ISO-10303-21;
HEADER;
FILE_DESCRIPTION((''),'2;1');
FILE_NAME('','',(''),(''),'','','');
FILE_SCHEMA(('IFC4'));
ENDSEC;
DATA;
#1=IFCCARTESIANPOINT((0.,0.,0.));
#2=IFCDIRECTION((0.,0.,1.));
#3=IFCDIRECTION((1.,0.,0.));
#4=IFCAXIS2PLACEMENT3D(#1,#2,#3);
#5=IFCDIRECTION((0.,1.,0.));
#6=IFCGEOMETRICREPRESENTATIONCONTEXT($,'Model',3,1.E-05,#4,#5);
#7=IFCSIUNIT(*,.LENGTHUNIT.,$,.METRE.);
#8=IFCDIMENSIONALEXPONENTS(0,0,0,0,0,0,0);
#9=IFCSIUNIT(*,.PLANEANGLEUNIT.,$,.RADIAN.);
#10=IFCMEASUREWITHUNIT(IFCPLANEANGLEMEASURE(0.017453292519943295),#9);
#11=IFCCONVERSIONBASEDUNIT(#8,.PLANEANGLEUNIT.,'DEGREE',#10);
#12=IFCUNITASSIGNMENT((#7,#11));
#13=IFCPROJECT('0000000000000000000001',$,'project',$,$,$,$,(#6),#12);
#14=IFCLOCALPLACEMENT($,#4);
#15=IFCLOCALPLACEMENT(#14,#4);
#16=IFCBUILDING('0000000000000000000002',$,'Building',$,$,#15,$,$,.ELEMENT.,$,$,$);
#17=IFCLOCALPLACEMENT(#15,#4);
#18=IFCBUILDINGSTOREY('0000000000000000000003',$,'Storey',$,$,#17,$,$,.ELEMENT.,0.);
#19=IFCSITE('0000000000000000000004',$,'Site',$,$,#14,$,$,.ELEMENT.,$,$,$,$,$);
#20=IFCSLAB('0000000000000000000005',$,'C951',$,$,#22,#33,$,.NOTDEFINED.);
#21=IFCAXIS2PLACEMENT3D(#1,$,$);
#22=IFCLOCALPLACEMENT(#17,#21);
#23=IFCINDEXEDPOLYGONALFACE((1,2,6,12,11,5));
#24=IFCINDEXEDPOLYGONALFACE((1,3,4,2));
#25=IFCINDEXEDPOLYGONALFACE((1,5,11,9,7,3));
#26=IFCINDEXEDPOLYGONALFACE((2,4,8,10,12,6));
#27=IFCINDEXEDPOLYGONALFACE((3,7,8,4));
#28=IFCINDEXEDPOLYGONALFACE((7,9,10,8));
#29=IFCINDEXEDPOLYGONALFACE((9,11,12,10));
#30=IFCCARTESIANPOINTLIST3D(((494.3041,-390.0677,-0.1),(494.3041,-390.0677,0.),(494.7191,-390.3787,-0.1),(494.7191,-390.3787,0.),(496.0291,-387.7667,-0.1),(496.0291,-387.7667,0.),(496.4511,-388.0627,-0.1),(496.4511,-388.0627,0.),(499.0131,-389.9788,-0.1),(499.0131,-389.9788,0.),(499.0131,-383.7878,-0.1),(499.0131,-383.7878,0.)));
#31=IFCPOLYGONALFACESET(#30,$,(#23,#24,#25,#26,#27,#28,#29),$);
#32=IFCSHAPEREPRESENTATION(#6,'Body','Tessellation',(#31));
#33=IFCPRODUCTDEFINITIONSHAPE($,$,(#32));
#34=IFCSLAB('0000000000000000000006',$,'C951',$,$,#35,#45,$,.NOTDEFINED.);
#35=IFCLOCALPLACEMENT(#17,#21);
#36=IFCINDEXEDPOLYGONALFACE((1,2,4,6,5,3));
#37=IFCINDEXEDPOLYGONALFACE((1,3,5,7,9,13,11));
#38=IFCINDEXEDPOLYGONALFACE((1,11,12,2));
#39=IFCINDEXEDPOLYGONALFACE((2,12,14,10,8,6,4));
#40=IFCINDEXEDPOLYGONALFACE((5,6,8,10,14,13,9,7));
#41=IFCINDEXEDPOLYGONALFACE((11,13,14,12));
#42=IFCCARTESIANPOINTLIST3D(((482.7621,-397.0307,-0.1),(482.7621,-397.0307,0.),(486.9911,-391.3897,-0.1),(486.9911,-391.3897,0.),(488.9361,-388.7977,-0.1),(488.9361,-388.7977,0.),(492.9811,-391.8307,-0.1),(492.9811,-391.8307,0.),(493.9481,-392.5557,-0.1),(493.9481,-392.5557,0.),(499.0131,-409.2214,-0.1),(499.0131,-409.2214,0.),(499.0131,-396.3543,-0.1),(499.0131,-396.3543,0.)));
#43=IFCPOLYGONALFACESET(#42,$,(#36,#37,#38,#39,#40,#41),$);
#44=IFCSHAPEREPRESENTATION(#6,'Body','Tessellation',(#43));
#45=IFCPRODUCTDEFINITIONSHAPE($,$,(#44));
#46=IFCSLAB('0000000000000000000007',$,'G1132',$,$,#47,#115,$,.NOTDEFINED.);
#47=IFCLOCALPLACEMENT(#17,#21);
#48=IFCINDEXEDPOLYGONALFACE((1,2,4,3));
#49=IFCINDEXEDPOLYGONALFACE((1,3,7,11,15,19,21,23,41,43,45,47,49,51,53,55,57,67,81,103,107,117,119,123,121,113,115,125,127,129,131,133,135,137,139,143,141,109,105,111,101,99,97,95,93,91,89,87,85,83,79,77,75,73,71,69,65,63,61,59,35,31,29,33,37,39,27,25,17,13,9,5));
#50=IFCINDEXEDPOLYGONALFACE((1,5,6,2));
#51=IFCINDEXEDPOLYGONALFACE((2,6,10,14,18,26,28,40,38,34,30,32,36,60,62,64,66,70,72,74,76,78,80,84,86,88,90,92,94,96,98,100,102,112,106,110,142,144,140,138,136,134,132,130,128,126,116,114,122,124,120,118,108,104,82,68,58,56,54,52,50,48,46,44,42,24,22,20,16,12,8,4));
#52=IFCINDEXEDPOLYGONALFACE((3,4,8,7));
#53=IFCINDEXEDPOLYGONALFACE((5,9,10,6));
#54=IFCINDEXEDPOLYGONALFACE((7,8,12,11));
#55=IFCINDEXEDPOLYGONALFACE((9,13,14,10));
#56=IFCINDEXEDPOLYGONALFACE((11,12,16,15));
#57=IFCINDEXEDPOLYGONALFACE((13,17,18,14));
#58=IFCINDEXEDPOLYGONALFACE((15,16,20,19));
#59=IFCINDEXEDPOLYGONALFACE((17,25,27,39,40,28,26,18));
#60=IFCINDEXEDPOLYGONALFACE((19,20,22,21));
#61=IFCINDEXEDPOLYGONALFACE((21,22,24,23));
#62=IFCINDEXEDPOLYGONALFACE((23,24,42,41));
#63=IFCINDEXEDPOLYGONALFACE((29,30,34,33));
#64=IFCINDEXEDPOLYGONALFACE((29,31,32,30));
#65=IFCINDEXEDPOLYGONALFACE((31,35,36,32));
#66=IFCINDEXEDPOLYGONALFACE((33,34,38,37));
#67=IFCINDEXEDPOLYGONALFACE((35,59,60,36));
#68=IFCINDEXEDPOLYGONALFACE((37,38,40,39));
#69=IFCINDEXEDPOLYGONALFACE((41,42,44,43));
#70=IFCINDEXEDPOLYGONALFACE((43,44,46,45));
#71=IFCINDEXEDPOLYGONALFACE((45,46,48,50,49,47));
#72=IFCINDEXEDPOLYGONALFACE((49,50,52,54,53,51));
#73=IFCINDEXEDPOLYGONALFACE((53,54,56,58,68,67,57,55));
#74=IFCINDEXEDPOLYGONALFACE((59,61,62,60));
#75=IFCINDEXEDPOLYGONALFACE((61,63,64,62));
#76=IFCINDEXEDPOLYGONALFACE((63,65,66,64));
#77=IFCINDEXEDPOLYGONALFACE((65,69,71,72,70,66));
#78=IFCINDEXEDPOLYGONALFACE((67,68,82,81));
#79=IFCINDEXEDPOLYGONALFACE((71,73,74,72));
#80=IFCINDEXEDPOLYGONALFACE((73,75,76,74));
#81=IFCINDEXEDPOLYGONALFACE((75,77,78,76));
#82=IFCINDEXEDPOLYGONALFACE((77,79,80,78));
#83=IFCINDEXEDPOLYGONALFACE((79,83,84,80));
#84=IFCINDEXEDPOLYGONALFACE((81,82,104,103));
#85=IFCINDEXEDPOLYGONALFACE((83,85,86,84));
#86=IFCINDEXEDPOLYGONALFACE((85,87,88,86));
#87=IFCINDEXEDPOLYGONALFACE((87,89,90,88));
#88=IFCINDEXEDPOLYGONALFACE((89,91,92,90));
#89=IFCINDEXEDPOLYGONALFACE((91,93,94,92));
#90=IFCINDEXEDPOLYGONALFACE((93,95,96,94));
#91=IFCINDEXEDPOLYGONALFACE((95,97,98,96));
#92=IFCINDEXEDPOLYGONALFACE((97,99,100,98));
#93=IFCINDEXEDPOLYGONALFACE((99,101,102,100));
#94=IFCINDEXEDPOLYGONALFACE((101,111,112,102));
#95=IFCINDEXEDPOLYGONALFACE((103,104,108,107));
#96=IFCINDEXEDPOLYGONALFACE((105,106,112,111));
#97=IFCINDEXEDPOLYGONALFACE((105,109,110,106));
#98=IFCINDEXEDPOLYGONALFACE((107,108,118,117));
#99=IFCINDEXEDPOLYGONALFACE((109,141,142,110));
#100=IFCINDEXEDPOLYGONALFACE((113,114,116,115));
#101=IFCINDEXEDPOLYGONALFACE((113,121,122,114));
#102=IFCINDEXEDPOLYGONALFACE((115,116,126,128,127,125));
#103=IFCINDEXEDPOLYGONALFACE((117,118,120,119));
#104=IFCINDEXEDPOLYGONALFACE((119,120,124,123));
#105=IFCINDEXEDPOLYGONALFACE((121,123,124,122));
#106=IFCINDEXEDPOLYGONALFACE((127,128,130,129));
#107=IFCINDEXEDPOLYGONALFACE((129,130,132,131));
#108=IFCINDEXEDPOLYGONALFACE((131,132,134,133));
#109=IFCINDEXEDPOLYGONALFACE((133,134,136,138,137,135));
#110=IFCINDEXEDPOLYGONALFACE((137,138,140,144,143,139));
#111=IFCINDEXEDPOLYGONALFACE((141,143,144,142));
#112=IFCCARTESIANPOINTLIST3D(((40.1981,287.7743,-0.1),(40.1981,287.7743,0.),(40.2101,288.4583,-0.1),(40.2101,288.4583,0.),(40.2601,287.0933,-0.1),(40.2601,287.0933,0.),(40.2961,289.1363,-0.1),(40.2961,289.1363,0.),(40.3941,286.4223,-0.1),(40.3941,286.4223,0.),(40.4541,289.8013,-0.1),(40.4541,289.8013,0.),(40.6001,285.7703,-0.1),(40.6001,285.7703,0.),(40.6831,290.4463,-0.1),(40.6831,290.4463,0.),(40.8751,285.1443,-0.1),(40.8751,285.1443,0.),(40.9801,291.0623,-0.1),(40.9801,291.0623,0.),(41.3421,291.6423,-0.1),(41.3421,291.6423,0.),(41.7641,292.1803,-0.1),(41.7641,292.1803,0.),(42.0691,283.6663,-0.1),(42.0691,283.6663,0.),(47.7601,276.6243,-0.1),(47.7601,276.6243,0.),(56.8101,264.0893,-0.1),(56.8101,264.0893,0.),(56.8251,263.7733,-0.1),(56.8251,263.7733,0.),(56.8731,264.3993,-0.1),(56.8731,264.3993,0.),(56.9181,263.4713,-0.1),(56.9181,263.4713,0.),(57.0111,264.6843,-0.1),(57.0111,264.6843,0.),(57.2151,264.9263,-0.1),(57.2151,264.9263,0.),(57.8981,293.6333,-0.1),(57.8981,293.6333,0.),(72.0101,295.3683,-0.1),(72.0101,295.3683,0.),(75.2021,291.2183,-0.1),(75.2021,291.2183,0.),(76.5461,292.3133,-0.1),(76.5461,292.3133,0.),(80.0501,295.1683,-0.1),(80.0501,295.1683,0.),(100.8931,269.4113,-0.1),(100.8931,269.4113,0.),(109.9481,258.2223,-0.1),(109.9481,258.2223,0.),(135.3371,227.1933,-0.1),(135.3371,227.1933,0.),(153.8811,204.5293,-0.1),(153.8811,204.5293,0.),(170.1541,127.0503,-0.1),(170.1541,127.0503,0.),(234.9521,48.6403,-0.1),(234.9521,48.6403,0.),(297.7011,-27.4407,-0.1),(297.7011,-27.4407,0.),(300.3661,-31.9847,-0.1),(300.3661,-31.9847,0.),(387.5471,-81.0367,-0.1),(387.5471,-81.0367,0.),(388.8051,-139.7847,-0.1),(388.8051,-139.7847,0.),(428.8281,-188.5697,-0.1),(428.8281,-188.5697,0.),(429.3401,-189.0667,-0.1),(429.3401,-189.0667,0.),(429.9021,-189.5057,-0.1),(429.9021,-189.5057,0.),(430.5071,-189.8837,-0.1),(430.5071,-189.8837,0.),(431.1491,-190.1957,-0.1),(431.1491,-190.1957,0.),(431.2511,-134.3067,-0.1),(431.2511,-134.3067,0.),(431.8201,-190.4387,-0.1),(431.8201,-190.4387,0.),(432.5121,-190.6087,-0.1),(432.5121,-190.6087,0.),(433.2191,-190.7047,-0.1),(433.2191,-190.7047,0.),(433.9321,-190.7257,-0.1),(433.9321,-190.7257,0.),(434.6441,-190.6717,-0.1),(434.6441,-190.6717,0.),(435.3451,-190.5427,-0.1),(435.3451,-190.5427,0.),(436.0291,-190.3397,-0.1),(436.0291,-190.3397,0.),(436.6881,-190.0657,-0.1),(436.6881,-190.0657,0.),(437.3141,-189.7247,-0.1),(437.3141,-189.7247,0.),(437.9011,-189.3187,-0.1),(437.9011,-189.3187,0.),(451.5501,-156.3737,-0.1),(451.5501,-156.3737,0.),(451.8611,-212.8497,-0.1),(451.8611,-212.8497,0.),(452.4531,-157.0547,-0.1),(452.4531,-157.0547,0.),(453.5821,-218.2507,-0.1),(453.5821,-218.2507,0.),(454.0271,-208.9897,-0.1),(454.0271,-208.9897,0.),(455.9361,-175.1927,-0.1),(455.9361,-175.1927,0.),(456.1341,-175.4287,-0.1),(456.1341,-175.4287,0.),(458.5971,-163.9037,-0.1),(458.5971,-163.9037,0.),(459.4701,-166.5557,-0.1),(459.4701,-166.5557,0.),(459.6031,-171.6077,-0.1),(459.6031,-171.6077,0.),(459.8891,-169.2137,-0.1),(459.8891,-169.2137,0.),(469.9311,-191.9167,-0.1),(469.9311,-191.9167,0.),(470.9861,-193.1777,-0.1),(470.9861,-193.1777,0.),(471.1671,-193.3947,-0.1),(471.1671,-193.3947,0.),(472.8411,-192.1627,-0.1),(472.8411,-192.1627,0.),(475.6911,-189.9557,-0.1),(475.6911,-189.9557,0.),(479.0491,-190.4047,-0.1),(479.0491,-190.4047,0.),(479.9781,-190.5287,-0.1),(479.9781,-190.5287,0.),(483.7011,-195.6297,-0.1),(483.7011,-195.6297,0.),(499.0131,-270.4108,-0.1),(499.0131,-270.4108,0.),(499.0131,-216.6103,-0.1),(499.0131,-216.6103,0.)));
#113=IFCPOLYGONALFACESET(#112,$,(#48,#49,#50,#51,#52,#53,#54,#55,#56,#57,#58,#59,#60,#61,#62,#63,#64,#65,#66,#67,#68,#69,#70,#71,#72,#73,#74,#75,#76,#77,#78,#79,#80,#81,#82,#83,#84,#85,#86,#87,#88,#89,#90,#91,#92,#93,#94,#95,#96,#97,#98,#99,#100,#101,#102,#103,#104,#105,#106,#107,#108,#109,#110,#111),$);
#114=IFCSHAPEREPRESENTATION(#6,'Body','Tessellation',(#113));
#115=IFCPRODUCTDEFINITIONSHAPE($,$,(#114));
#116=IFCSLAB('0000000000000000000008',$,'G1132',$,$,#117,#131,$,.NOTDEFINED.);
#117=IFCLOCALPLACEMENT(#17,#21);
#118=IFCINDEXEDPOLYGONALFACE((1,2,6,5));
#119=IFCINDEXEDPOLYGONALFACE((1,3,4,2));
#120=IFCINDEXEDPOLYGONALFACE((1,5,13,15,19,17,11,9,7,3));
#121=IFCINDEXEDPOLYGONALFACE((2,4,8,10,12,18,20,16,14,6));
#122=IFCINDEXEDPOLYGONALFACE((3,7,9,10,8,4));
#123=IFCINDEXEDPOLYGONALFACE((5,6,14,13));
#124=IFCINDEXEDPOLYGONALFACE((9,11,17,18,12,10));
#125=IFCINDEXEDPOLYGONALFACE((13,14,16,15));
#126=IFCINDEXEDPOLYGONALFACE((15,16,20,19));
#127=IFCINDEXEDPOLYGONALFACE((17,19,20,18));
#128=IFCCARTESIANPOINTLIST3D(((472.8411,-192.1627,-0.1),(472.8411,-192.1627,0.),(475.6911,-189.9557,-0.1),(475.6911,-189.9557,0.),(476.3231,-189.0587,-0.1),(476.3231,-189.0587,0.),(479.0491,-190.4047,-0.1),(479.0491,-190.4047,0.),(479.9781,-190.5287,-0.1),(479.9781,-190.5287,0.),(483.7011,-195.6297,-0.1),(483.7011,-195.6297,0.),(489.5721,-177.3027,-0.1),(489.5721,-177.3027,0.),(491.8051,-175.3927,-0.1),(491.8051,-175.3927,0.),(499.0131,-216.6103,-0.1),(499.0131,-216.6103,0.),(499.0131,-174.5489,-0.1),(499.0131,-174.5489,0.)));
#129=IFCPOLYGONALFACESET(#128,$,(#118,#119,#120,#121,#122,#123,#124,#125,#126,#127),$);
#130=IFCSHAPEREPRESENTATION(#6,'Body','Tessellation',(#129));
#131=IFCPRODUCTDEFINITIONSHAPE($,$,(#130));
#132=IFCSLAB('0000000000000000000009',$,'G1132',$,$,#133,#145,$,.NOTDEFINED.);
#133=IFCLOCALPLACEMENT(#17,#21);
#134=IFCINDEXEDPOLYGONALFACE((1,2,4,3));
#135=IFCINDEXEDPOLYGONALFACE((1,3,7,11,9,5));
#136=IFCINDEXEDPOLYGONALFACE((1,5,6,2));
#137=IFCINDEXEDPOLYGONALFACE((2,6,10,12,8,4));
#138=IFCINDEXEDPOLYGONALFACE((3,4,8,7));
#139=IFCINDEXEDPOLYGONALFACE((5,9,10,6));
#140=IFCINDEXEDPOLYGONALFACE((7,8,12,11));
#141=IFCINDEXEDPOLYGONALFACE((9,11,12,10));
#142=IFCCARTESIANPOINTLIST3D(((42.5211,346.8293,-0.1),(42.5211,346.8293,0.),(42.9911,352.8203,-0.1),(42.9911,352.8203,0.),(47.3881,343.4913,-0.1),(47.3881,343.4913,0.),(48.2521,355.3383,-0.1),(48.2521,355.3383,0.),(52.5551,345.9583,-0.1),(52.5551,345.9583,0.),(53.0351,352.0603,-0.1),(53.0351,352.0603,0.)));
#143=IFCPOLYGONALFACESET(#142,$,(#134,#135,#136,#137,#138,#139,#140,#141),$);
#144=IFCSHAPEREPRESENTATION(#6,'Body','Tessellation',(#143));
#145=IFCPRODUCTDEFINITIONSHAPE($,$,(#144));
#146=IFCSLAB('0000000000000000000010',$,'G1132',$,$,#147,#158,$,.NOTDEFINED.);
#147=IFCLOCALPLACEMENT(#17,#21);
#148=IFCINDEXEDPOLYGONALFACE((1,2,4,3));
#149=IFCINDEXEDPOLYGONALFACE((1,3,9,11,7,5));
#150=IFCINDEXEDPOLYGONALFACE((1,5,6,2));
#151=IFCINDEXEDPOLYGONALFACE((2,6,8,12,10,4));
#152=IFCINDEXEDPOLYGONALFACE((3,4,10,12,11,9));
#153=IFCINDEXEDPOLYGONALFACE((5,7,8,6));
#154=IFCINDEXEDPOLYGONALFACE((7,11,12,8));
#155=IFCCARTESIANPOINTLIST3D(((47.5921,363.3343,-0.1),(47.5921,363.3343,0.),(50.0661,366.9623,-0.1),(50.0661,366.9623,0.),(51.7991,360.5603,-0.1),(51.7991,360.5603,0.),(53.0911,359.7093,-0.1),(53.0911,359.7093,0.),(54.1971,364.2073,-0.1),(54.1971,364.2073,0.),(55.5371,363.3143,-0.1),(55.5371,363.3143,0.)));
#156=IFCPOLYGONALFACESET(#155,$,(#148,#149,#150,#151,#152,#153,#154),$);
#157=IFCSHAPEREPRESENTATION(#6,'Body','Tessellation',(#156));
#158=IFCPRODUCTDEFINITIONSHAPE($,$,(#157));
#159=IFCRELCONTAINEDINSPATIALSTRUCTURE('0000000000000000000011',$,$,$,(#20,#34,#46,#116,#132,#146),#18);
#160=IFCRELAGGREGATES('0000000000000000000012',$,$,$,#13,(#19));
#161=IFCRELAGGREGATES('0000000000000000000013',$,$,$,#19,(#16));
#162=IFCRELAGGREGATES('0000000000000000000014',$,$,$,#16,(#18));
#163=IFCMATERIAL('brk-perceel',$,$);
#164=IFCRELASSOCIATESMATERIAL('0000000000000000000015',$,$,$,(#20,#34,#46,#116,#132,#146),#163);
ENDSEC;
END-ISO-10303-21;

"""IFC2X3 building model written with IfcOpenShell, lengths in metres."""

from ifc_helpers import new_model, entity, si_unit, converted_unit, direction, frame, origin_with_axes, place, context, project, spatial, polyline, outline, extrude, material, element, save


model = new_model("IFC2X3")

# Units and contexts
model_context = context("Model", 3, precision=1e-05, world=origin_with_axes(), true_north=direction((0.0, 1.0, 0.0)))
ifc_project = project(units=[si_unit("LENGTHUNIT", "METRE"), converted_unit("PLANEANGLEUNIT", "DEGREE", entity("IfcPlaneAngleMeasure", 0.017453292519943295), si_unit("PLANEANGLEUNIT", "RADIAN"), dimensions=[0, 0, 0, 0, 0, 0, 0])], contexts=[model_context])

# Site, building, storey
site_placement = place(None, origin_with_axes())
site = spatial("IfcSite", under=ifc_project, at=site_placement, Name="Site", CompositionType="ELEMENT")
building_placement = place(site_placement, origin_with_axes())
building = spatial("IfcBuilding", under=site, at=building_placement, Name="Building", CompositionType="ELEMENT")
storey_placement = place(building_placement, origin_with_axes())
storey = spatial("IfcBuildingStorey", under=building, at=storey_placement, Name="Storey", CompositionType="ELEMENT", Elevation=0.0)

# Slabs
ifc_material = material(Name="brk-perceel")
slab_1_placement = place(storey_placement, frame((0.0, 0.0, -0.1), z_axis=(0.0, 0.0, 1.0), x_axis=(1.0, 0.0, 0.0)))
element("IfcSlab", 1, at=slab_1_placement, inside=storey, material=ifc_material, Name="C951", PredefinedType="NOTDEFINED", context=model_context, shape_type="SweptSolid", body=[
    extrude(outline(polyline([(496.4511, -388.0627), (494.7191, -390.3787), (494.3041, -390.0677), (496.0291, -387.7667), (499.0131, -383.7878), (499.0131, -389.9788), (496.4511, -388.0627)])), origin_with_axes(), (0.0, 0.0, 1.0), 0.1),
])
slab_2_placement = place(storey_placement, frame((0.0, 0.0, -0.1), z_axis=(0.0, 0.0, 1.0), x_axis=(1.0, 0.0, 0.0)))
element("IfcSlab", 2, at=slab_2_placement, inside=storey, material=ifc_material, Name="C951", PredefinedType="NOTDEFINED", context=model_context, shape_type="SweptSolid", body=[
    extrude(outline(polyline([(482.7621, -397.0307), (486.9911, -391.3897), (488.9361, -388.7977), (492.9811, -391.8307), (493.9481, -392.5557), (499.0131, -396.3543), (499.0131, -409.2214), (482.7621, -397.0307)])), origin_with_axes(), (0.0, 0.0, 1.0), 0.1),
])
slab_3_placement = place(storey_placement, frame((0.0, 0.0, -0.1), z_axis=(0.0, 0.0, 1.0), x_axis=(1.0, 0.0, 0.0)))
element("IfcSlab", 3, at=slab_3_placement, inside=storey, material=ifc_material, Name="G1132", PredefinedType="NOTDEFINED", context=model_context, shape_type="SweptSolid", body=[
    extrude(outline(polyline([(453.5821, -218.2507), (451.8611, -212.8497), (454.0271, -208.9897), (437.9011, -189.3187), (437.3141, -189.7247), (436.6881, -190.0657), (436.0291, -190.3397), (435.3451, -190.5427), (434.6441, -190.6717), (433.9321, -190.7257), (433.2191, -190.7047), (432.5121, -190.6087), (431.8201, -190.4387), (431.1491, -190.1957), (430.5071, -189.8837), (429.9021, -189.5057), (429.3401, -189.0667), (428.8281, -188.5697), (388.8051, -139.7847), (300.3661, -31.9847), (297.7011, -27.4407), (234.9521, 48.6403), (170.1541, 127.0503), (56.9181, 263.4713), (56.8251, 263.7733), (56.8101, 264.0893), (56.8731, 264.3993), (57.0111, 264.6843), (57.2151, 264.9263), (47.7601, 276.6243), (42.0691, 283.6663), (40.8751, 285.1443), (40.6001, 285.7703), (40.3941, 286.4223), (40.2601, 287.0933), (40.1981, 287.7743), (40.2101, 288.4583), (40.2961, 289.1363), (40.4541, 289.8013), (40.6831, 290.4463), (40.9801, 291.0623), (41.3421, 291.6423), (41.7641, 292.1803), (57.8981, 293.6333), (72.0101, 295.3683), (75.2021, 291.2183), (76.5461, 292.3133), (80.0501, 295.1683), (100.8931, 269.4113), (109.9481, 258.2223), (135.3371, 227.1933), (153.8811, 204.5293), (387.5471, -81.0367), (431.2511, -134.3067), (451.5501, -156.3737), (452.4531, -157.0547), (458.5971, -163.9037), (459.4701, -166.5557), (459.8891, -169.2137), (459.6031, -171.6077), (455.9361, -175.1927), (456.1341, -175.4287), (469.9311, -191.9167), (470.9861, -193.1777), (471.1671, -193.3947), (472.8411, -192.1627), (475.6911, -189.9557), (479.0491, -190.4047), (479.9781, -190.5287), (483.7011, -195.6297), (499.0131, -216.6103), (499.0131, -270.4108), (453.5821, -218.2507)])), origin_with_axes(), (0.0, 0.0, 1.0), 0.1),
])
slab_4_placement = place(storey_placement, frame((0.0, 0.0, -0.1), z_axis=(0.0, 0.0, 1.0), x_axis=(1.0, 0.0, 0.0)))
element("IfcSlab", 4, at=slab_4_placement, inside=storey, material=ifc_material, Name="G1132", PredefinedType="NOTDEFINED", context=model_context, shape_type="SweptSolid", body=[
    extrude(outline(polyline([(483.7011, -195.6297), (479.9781, -190.5287), (479.0491, -190.4047), (475.6911, -189.9557), (472.8411, -192.1627), (476.3231, -189.0587), (489.5721, -177.3027), (491.8051, -175.3927), (499.0131, -174.5489), (499.0131, -216.6103), (483.7011, -195.6297)])), origin_with_axes(), (0.0, 0.0, 1.0), 0.1),
])
slab_5_placement = place(storey_placement, frame((0.0, 0.0, -0.1), z_axis=(0.0, 0.0, 1.0), x_axis=(1.0, 0.0, 0.0)))
element("IfcSlab", 5, at=slab_5_placement, inside=storey, material=ifc_material, Name="G1132", PredefinedType="NOTDEFINED", context=model_context, shape_type="SweptSolid", body=[
    extrude(outline(polyline([(52.5551, 345.9583), (47.3881, 343.4913), (42.5211, 346.8293), (42.9911, 352.8203), (48.2521, 355.3383), (53.0351, 352.0603), (52.5551, 345.9583)])), origin_with_axes(), (0.0, 0.0, 1.0), 0.1),
])
slab_6_placement = place(storey_placement, frame((0.0, 0.0, -0.1), z_axis=(0.0, 0.0, 1.0), x_axis=(1.0, 0.0, 0.0)))
element("IfcSlab", 6, at=slab_6_placement, inside=storey, material=ifc_material, Name="G1132", PredefinedType="NOTDEFINED", context=model_context, shape_type="SweptSolid", body=[
    extrude(outline(polyline([(47.5921, 363.3343), (50.0661, 366.9623), (54.1971, 364.2073), (55.5371, 363.3143), (53.0911, 359.7093), (51.7991, 360.5603), (47.5921, 363.3343)])), origin_with_axes(), (0.0, 0.0, 1.0), 0.1),
])

save(model, "model.ifc")
